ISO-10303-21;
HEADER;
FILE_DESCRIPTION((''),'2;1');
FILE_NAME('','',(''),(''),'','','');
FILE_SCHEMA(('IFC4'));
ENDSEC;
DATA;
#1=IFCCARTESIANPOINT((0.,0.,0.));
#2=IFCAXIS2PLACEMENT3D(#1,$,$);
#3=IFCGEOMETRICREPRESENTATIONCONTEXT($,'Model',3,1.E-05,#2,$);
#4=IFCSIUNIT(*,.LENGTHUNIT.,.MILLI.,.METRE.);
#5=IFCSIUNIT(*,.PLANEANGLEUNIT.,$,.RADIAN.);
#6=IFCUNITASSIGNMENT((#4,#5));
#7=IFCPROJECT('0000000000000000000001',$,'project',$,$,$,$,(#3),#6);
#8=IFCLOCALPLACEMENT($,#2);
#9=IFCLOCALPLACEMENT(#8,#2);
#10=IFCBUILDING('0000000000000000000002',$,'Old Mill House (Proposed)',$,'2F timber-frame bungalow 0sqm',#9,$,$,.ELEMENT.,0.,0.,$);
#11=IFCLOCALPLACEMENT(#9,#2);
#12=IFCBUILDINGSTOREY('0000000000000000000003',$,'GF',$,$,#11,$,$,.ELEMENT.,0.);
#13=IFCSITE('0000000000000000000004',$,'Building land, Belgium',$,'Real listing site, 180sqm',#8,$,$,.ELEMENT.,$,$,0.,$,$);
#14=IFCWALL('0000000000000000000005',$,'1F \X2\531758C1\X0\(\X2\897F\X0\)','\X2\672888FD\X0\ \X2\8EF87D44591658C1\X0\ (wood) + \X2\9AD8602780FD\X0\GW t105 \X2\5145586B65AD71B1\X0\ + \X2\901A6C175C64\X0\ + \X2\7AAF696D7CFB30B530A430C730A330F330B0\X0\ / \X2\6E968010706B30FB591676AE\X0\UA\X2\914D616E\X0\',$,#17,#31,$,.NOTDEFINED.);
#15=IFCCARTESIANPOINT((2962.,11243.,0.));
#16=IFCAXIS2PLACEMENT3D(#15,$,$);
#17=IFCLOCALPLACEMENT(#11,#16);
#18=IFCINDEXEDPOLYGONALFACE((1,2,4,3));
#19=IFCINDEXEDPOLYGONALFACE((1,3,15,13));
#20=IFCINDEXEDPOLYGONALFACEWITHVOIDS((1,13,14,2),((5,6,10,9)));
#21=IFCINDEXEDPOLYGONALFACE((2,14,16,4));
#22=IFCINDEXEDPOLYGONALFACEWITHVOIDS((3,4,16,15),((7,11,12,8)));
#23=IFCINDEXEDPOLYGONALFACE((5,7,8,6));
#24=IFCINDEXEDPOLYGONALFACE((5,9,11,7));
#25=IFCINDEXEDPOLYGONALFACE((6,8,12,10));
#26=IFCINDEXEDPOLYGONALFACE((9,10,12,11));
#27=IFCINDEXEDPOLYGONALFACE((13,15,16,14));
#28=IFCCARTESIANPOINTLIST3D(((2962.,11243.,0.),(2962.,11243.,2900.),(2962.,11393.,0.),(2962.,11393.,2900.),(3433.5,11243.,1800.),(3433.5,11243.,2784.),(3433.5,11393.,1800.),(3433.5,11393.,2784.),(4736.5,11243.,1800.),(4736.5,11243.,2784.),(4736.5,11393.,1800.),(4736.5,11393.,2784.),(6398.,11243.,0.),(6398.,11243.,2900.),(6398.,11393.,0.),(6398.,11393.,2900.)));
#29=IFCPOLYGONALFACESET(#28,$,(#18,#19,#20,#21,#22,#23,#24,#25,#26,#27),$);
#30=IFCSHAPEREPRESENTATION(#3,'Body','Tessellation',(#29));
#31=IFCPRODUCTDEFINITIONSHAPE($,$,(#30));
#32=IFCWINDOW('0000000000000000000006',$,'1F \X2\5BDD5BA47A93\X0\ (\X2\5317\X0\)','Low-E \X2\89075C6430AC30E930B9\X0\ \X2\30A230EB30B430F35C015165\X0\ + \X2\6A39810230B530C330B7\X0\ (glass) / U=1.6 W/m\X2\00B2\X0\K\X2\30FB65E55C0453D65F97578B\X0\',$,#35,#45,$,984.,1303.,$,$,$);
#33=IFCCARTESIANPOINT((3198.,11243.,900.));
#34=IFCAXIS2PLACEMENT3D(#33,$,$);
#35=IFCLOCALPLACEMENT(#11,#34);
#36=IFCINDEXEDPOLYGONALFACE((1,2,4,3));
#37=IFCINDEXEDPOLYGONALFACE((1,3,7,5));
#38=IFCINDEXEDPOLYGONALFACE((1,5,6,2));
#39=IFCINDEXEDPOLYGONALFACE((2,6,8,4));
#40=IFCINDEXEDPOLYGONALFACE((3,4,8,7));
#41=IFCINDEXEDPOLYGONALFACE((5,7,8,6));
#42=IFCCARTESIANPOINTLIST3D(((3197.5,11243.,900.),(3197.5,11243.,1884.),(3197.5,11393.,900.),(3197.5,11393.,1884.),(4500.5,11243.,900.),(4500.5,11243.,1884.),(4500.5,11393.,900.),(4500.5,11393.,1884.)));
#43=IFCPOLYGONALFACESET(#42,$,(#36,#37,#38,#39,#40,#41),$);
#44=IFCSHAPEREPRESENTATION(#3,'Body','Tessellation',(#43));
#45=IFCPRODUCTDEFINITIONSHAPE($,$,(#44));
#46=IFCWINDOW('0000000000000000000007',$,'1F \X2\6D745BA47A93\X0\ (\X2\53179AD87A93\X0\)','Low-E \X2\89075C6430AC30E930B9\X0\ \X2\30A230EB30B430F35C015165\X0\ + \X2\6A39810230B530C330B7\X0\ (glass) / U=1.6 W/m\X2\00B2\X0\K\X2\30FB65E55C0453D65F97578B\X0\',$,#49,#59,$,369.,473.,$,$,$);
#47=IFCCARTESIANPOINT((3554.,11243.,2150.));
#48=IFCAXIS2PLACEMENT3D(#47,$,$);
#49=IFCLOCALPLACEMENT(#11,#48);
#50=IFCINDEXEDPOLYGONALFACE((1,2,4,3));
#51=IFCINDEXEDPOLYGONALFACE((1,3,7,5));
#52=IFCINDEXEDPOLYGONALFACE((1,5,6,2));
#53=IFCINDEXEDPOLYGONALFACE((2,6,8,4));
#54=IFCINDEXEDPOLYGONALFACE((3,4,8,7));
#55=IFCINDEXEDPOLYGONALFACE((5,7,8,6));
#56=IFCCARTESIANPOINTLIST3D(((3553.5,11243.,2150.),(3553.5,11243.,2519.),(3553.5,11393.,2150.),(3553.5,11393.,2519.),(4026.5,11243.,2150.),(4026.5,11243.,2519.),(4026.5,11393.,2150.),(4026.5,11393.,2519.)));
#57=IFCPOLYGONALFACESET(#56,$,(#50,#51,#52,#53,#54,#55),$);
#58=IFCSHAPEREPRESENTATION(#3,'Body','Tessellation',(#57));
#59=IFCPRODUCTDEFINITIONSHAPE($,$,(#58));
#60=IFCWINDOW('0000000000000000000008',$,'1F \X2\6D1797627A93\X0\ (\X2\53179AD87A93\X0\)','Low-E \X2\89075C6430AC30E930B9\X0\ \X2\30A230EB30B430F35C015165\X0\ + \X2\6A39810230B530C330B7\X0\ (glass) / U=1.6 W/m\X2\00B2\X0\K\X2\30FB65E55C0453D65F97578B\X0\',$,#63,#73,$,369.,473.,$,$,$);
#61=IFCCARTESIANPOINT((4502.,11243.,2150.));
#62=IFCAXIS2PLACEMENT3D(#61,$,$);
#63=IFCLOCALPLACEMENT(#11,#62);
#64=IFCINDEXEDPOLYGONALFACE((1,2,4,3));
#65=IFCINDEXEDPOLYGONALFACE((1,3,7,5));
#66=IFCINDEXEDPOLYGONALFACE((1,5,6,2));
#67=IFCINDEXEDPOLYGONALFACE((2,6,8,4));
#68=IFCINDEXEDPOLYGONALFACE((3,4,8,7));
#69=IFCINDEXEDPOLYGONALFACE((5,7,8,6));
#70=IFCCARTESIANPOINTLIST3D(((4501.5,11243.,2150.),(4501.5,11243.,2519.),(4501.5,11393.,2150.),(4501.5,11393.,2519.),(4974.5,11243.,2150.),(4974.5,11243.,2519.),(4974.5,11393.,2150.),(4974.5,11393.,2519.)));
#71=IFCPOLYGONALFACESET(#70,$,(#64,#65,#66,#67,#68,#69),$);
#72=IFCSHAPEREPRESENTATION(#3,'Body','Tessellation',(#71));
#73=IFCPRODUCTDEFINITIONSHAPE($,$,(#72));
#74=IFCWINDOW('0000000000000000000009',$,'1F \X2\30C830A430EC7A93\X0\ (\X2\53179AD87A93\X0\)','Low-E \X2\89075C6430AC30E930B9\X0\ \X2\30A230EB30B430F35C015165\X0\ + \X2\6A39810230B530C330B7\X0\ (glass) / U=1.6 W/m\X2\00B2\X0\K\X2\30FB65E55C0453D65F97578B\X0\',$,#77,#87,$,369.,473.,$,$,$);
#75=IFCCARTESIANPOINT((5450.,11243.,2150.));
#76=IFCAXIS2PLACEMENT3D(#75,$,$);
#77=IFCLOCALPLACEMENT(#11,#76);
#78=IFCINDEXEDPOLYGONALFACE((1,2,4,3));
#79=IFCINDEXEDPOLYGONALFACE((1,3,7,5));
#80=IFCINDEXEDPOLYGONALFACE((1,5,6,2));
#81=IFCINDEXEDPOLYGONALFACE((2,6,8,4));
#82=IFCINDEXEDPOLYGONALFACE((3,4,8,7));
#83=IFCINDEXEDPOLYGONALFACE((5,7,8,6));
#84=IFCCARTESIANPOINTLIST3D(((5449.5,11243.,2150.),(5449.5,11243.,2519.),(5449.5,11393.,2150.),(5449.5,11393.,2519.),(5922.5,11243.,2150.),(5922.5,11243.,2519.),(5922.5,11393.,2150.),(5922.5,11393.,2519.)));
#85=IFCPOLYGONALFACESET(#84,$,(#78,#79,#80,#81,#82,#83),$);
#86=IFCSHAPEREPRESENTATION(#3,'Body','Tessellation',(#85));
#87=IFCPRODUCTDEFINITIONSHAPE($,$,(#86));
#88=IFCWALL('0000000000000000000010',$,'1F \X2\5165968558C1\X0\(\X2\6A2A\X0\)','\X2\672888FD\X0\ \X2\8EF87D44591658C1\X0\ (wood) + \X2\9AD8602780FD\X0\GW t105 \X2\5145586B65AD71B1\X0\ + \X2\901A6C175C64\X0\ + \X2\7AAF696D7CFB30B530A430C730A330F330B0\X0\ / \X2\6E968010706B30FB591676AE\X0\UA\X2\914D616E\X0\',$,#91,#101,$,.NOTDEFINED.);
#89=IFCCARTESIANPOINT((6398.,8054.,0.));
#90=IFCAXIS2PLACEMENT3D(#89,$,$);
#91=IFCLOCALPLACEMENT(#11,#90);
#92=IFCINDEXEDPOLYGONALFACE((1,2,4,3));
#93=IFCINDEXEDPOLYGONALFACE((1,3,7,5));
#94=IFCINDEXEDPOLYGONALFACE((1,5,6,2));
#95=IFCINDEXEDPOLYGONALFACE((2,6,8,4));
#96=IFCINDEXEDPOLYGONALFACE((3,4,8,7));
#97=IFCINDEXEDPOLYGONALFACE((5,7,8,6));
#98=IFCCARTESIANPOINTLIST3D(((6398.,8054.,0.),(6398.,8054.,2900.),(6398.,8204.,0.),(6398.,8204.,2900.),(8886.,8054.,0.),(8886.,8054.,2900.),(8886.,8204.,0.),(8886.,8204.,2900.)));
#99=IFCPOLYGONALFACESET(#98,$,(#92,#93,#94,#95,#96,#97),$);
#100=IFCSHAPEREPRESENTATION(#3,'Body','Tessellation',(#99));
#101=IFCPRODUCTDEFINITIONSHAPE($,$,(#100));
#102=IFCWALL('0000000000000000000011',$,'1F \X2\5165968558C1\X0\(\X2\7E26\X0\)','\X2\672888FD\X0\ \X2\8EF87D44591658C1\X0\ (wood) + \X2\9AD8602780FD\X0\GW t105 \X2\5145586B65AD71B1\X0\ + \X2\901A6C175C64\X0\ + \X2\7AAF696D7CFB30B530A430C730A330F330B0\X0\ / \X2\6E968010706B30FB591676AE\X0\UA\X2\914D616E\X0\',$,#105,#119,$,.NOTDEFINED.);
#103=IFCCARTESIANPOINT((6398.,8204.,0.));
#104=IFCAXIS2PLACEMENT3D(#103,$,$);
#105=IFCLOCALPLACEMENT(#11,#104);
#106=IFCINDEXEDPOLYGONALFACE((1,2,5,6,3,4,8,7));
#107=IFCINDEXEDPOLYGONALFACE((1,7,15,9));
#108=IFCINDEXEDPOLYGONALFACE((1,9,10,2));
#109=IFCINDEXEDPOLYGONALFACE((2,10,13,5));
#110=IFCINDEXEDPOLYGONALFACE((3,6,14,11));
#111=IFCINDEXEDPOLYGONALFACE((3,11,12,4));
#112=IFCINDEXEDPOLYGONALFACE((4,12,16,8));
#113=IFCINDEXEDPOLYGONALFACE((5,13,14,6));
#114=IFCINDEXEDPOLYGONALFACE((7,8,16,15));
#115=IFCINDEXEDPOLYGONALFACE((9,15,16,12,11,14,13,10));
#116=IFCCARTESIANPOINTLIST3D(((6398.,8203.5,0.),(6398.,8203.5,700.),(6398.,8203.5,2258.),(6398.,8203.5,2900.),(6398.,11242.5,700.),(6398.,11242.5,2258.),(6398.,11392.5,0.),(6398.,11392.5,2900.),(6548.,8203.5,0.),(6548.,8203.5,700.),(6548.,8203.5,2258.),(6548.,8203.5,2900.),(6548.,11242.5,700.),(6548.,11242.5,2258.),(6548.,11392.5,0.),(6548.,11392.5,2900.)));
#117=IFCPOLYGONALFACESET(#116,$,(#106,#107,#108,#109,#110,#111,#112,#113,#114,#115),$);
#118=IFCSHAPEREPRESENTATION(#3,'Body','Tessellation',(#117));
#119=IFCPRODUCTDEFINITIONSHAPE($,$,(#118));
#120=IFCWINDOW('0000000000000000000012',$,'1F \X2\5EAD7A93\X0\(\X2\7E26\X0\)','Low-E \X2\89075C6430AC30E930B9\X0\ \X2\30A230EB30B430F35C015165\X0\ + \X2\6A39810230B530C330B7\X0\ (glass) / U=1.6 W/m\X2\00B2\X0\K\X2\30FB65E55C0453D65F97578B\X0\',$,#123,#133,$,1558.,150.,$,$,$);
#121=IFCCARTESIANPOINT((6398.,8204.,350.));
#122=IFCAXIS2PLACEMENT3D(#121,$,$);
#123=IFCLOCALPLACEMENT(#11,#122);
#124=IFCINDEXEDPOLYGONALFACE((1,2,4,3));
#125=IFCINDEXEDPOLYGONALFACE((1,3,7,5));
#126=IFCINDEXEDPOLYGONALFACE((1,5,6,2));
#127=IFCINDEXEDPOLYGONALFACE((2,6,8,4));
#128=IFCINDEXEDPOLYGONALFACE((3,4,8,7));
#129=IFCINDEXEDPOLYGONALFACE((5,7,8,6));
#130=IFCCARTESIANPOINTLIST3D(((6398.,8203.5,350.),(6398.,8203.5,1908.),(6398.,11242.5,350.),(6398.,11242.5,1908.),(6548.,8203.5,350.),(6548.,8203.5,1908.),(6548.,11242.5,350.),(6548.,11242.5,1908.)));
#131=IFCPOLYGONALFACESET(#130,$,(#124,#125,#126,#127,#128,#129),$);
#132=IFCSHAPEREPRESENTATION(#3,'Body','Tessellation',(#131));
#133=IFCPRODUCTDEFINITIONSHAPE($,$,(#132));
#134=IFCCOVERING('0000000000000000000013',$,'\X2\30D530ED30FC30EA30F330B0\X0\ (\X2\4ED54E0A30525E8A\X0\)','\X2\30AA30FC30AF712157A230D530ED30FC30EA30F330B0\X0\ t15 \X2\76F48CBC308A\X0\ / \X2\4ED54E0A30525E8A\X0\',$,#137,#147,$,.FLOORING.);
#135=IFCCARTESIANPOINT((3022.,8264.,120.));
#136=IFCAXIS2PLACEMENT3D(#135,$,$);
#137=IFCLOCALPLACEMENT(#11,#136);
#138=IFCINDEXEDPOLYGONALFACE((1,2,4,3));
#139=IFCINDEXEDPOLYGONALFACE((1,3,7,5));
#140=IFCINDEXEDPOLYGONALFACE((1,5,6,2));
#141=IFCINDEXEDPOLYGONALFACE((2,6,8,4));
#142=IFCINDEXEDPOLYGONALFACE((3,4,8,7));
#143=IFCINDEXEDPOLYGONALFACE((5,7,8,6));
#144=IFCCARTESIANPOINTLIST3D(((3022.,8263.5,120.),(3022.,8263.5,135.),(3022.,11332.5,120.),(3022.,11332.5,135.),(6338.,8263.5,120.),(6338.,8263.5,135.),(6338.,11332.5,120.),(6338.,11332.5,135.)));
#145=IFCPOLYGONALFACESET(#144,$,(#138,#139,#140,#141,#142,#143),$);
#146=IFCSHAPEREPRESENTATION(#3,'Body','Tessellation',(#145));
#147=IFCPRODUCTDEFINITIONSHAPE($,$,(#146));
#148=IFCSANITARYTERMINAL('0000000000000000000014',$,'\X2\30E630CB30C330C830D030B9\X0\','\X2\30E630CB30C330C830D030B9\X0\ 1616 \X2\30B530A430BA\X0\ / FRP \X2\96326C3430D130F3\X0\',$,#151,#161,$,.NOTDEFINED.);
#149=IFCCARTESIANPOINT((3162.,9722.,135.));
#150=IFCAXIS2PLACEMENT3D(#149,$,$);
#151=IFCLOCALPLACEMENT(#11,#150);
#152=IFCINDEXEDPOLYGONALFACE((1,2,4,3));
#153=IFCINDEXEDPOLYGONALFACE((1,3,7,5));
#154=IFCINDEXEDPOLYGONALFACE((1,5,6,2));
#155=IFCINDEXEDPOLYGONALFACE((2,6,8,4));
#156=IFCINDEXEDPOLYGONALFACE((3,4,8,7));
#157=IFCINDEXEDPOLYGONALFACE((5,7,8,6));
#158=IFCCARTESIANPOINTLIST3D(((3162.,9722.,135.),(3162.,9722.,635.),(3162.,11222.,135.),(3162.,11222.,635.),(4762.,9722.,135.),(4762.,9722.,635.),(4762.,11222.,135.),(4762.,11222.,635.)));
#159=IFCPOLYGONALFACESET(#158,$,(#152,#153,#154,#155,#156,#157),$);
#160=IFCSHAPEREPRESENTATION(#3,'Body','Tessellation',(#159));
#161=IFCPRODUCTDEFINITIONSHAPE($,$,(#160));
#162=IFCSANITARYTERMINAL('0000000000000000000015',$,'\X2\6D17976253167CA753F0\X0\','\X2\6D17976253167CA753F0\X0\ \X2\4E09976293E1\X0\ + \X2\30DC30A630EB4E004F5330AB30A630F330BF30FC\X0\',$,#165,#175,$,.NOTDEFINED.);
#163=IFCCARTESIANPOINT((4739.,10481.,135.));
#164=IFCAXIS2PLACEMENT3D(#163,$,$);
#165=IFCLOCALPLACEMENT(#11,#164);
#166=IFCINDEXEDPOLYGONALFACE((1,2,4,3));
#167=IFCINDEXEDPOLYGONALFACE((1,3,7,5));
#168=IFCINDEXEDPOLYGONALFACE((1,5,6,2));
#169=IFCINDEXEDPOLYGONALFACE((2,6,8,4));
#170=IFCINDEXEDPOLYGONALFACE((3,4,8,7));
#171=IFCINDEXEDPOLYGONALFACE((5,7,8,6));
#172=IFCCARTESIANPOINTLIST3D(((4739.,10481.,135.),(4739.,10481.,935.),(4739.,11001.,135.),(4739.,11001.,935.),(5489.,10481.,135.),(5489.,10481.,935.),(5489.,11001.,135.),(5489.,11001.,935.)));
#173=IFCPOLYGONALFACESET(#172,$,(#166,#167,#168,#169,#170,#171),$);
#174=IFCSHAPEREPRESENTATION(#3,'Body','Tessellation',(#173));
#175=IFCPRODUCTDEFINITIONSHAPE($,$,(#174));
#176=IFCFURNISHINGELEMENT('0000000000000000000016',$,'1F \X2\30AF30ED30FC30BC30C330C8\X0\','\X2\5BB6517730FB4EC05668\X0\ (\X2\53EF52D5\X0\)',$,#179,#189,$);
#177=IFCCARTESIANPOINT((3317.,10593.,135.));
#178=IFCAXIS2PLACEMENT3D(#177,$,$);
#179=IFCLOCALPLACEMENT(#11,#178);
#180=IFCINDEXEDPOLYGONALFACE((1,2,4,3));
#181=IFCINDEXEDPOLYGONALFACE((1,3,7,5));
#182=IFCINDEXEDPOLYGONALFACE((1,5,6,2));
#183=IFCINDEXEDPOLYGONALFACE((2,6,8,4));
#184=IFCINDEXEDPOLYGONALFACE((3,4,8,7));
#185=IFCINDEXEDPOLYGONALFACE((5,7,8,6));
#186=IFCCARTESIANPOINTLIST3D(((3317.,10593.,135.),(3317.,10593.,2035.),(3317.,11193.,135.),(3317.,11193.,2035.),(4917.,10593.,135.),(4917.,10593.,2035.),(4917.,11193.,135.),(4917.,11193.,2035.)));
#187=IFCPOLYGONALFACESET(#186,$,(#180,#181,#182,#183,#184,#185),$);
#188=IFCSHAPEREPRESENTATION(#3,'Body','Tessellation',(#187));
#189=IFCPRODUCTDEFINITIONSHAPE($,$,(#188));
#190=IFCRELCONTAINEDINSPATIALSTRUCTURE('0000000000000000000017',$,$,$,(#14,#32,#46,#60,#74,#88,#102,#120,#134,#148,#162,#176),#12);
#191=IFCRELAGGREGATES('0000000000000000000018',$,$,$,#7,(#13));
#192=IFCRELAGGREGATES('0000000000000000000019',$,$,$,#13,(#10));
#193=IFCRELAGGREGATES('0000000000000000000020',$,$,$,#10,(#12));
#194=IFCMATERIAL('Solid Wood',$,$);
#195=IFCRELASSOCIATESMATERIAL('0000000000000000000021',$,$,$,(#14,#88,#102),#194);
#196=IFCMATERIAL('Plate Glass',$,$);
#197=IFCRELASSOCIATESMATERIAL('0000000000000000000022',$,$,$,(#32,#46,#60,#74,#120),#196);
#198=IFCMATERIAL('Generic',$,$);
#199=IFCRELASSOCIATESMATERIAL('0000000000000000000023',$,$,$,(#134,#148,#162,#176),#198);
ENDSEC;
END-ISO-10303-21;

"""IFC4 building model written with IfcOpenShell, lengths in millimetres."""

from ifc_helpers import new_model, si_unit, frame, frame_2d, origin, place, context, project, spatial, rectangle, extrude, material, element, fill, save


model = new_model("IFC4")

# Units and contexts
model_context = context("Model", 3, precision=1e-05, world=origin())
ifc_project = project(units=[si_unit("LENGTHUNIT", "METRE", prefix="MILLI"), si_unit("PLANEANGLEUNIT", "RADIAN")], contexts=[model_context])

# Site, building, storey
site_placement = place(None, origin())
site = spatial("IfcSite", under=ifc_project, at=site_placement, Name="Building land, Belgium", ObjectType="Real listing site, 180sqm", CompositionType="ELEMENT", RefElevation=0.0)
building_placement = place(site_placement, origin())
building = spatial("IfcBuilding", under=site, at=building_placement, Name="Old Mill House (Proposed)", ObjectType="2F timber-frame bungalow 0sqm", CompositionType="ELEMENT", ElevationOfRefHeight=0.0, ElevationOfTerrain=0.0)
storey_placement = place(building_placement, origin())
storey = spatial("IfcBuildingStorey", under=building, at=storey_placement, Name="GF", CompositionType="ELEMENT", Elevation=0.0)

# Shared definitions
ifc_material_1 = material(Name="Solid Wood")

# Wall, openings, windows
wall_1_placement = place(storey_placement, frame((2962.0, 11243.0, 0.0)))
wall_1 = element("IfcWall", 1, at=wall_1_placement, inside=storey, material=ifc_material_1, Name="1F 北壁(西)", Description="木製 軸組外壁 (wood) + 高性能GW t105 充填断熱 + 通気層 + 窯業系サイディング / 準耐火・外皮UA配慮", PredefinedType="NOTDEFINED", context=model_context, shape_type="SweptSolid", body=[
    extrude(rectangle(XDim=3436.0, YDim=150.0, at=frame_2d((1718.0, 75.0))), frame((2962.0, 11243.0, 0.0)), (0.0, 0.0, 1.0), 2900.0),
])
opening_1_placement = place(storey_placement, frame((3198.0, 11243.0, 900.0)))
opening_1 = element("IfcOpeningElement", 2, at=opening_1_placement, cuts=wall_1, PredefinedType="NOTDEFINED", context=model_context, shape_type="SweptSolid", body=[
    extrude(rectangle(XDim=1303.0, YDim=150.0, at=frame_2d((651.0, 75.0))), frame((3198.0, 11243.0, 900.0)), (0.0, 0.0, 1.0), 984.0),
])
opening_2_placement = place(storey_placement, frame((3554.0, 11243.0, 2150.0)))
opening_2 = element("IfcOpeningElement", 3, at=opening_2_placement, cuts=wall_1, PredefinedType="NOTDEFINED", context=model_context, shape_type="SweptSolid", body=[
    extrude(rectangle(XDim=473.0, YDim=150.0, at=frame_2d((236.0, 75.0))), frame((3554.0, 11243.0, 2150.0)), (0.0, 0.0, 1.0), 369.0),
])
opening_3_placement = place(storey_placement, frame((4502.0, 11243.0, 2150.0)))
opening_3 = element("IfcOpeningElement", 4, at=opening_3_placement, cuts=wall_1, PredefinedType="NOTDEFINED", context=model_context, shape_type="SweptSolid", body=[
    extrude(rectangle(XDim=473.0, YDim=150.0, at=frame_2d((236.0, 75.0))), frame((4502.0, 11243.0, 2150.0)), (0.0, 0.0, 1.0), 369.0),
])
opening_4_placement = place(storey_placement, frame((5450.0, 11243.0, 2150.0)))
opening_4 = element("IfcOpeningElement", 5, at=opening_4_placement, cuts=wall_1, PredefinedType="NOTDEFINED", context=model_context, shape_type="SweptSolid", body=[
    extrude(rectangle(XDim=473.0, YDim=150.0, at=frame_2d((236.0, 75.0))), frame((5450.0, 11243.0, 2150.0)), (0.0, 0.0, 1.0), 369.0),
])
ifc_material_2 = material(Name="Plate Glass")
window_1_placement = place(storey_placement, frame((3198.0, 11243.0, 900.0)))
window_1 = element("IfcWindow", 6, at=window_1_placement, inside=storey, material=ifc_material_2, Name="1F 寝室窓 (北)", Description="Low-E 複層ガラス アルゴン封入 + 樹脂サッシ (glass) / U=1.6 W/m²K・日射取得型", OverallHeight=984.0, OverallWidth=1303.0, context=model_context, shape_type="SweptSolid", body=[
    extrude(rectangle(XDim=1303.0, YDim=150.0, at=frame_2d((651.0, 75.0))), frame((3198.0, 11243.0, 900.0)), (0.0, 0.0, 1.0), 984.0),
])
fill(opening_1, window_1)
window_2_placement = place(storey_placement, frame((3554.0, 11243.0, 2150.0)))
window_2 = element("IfcWindow", 7, at=window_2_placement, inside=storey, material=ifc_material_2, Name="1F 浴室窓 (北高窓)", Description="Low-E 複層ガラス アルゴン封入 + 樹脂サッシ (glass) / U=1.6 W/m²K・日射取得型", OverallHeight=369.0, OverallWidth=473.0, context=model_context, shape_type="SweptSolid", body=[
    extrude(rectangle(XDim=473.0, YDim=150.0, at=frame_2d((236.0, 75.0))), frame((3554.0, 11243.0, 2150.0)), (0.0, 0.0, 1.0), 369.0),
])
fill(opening_2, window_2)
window_3_placement = place(storey_placement, frame((4502.0, 11243.0, 2150.0)))
window_3 = element("IfcWindow", 8, at=window_3_placement, inside=storey, material=ifc_material_2, Name="1F 洗面窓 (北高窓)", Description="Low-E 複層ガラス アルゴン封入 + 樹脂サッシ (glass) / U=1.6 W/m²K・日射取得型", OverallHeight=369.0, OverallWidth=473.0, context=model_context, shape_type="SweptSolid", body=[
    extrude(rectangle(XDim=473.0, YDim=150.0, at=frame_2d((236.0, 75.0))), frame((4502.0, 11243.0, 2150.0)), (0.0, 0.0, 1.0), 369.0),
])
fill(opening_3, window_3)
window_4_placement = place(storey_placement, frame((5450.0, 11243.0, 2150.0)))
window_4 = element("IfcWindow", 9, at=window_4_placement, inside=storey, material=ifc_material_2, Name="1F トイレ窓 (北高窓)", Description="Low-E 複層ガラス アルゴン封入 + 樹脂サッシ (glass) / U=1.6 W/m²K・日射取得型", OverallHeight=369.0, OverallWidth=473.0, context=model_context, shape_type="SweptSolid", body=[
    extrude(rectangle(XDim=473.0, YDim=150.0, at=frame_2d((236.0, 75.0))), frame((5450.0, 11243.0, 2150.0)), (0.0, 0.0, 1.0), 369.0),
])
fill(opening_4, window_4)

# Wall
wall_2_placement = place(storey_placement, frame((6398.0, 8054.0, 0.0)))
element("IfcWall", 10, at=wall_2_placement, inside=storey, material=ifc_material_1, Name="1F 入隅壁(横)", Description="木製 軸組外壁 (wood) + 高性能GW t105 充填断熱 + 通気層 + 窯業系サイディング / 準耐火・外皮UA配慮", PredefinedType="NOTDEFINED", context=model_context, shape_type="SweptSolid", body=[
    extrude(rectangle(XDim=2488.0, YDim=150.0, at=frame_2d((1244.0, 75.0))), frame((6398.0, 8054.0, 0.0)), (0.0, 0.0, 1.0), 2900.0),
])

# Wall, opening, window
wall_3_placement = place(storey_placement, frame((6398.0, 8204.0, 0.0)))
wall_3 = element("IfcWall", 11, at=wall_3_placement, inside=storey, material=ifc_material_1, Name="1F 入隅壁(縦)", Description="木製 軸組外壁 (wood) + 高性能GW t105 充填断熱 + 通気層 + 窯業系サイディング / 準耐火・外皮UA配慮", PredefinedType="NOTDEFINED", context=model_context, shape_type="SweptSolid", body=[
    extrude(rectangle(XDim=150.0, YDim=3189.0, at=frame_2d((75.0, 1594.0))), frame((6398.0, 8204.0, 0.0)), (0.0, 0.0, 1.0), 2900.0),
])
opening_5_placement = place(storey_placement, frame((6398.0, 8204.0, 350.0)))
opening_5 = element("IfcOpeningElement", 12, at=opening_5_placement, cuts=wall_3, PredefinedType="NOTDEFINED", context=model_context, shape_type="SweptSolid", body=[
    extrude(rectangle(XDim=150.0, YDim=3039.0, at=frame_2d((75.0, 1519.0))), frame((6398.0, 8204.0, 350.0)), (0.0, 0.0, 1.0), 1558.0),
])
window_5_placement = place(storey_placement, frame((6398.0, 8204.0, 350.0)))
window_5 = element("IfcWindow", 13, at=window_5_placement, inside=storey, material=ifc_material_2, Name="1F 庭窓(縦)", Description="Low-E 複層ガラス アルゴン封入 + 樹脂サッシ (glass) / U=1.6 W/m²K・日射取得型", OverallHeight=1558.0, OverallWidth=150.0, context=model_context, shape_type="SweptSolid", body=[
    extrude(rectangle(XDim=150.0, YDim=3039.0, at=frame_2d((75.0, 1519.0))), frame((6398.0, 8204.0, 350.0)), (0.0, 0.0, 1.0), 1558.0),
])
fill(opening_5, window_5)

# Covering
ifc_material_3 = material(Name="Generic")
covering_placement = place(storey_placement, frame((3022.0, 8264.0, 120.0)))
element("IfcCovering", 14, at=covering_placement, inside=storey, material=ifc_material_3, Name="フローリング (仕上げ床)", Description="オーク無垢フローリング t15 直貼り / 仕上げ床", PredefinedType="FLOORING", context=model_context, shape_type="SweptSolid", body=[
    extrude(rectangle(XDim=3316.0, YDim=3069.0, at=frame_2d((1658.0, 1534.0))), frame((3022.0, 8264.0, 120.0)), (0.0, 0.0, 1.0), 15.0),
])

# Sanitary terminals
sanitary_terminal_1_placement = place(storey_placement, frame((3162.0, 9722.0, 135.0)))
element("IfcSanitaryTerminal", 15, at=sanitary_terminal_1_placement, inside=storey, material=ifc_material_3, Name="ユニットバス", Description="ユニットバス 1616 サイズ / FRP 防水パン", PredefinedType="NOTDEFINED", context=model_context, shape_type="SweptSolid", body=[
    extrude(rectangle(XDim=1600.0, YDim=1500.0, at=frame_2d((800.0, 750.0))), frame((3162.0, 9722.0, 135.0)), (0.0, 0.0, 1.0), 500.0),
])
sanitary_terminal_2_placement = place(storey_placement, frame((4739.0, 10481.0, 135.0)))
element("IfcSanitaryTerminal", 16, at=sanitary_terminal_2_placement, inside=storey, material=ifc_material_3, Name="洗面化粧台", Description="洗面化粧台 三面鏡 + ボウル一体カウンター", PredefinedType="NOTDEFINED", context=model_context, shape_type="SweptSolid", body=[
    extrude(rectangle(XDim=750.0, YDim=520.0, at=frame_2d((375.0, 260.0))), frame((4739.0, 10481.0, 135.0)), (0.0, 0.0, 1.0), 800.0),
])

# Furnishing element
furnishing_1_placement = place(storey_placement, frame((3317.0, 10593.0, 135.0)))
element("IfcFurnishingElement", 17, at=furnishing_1_placement, inside=storey, material=ifc_material_3, Name="1F クローゼット", Description="家具・什器 (可動)", context=model_context, shape_type="SweptSolid", body=[
    extrude(rectangle(XDim=1600.0, YDim=600.0, at=frame_2d((800.0, 300.0))), frame((3317.0, 10593.0, 135.0)), (0.0, 0.0, 1.0), 1900.0),
])

save(model, "model.ifc")
